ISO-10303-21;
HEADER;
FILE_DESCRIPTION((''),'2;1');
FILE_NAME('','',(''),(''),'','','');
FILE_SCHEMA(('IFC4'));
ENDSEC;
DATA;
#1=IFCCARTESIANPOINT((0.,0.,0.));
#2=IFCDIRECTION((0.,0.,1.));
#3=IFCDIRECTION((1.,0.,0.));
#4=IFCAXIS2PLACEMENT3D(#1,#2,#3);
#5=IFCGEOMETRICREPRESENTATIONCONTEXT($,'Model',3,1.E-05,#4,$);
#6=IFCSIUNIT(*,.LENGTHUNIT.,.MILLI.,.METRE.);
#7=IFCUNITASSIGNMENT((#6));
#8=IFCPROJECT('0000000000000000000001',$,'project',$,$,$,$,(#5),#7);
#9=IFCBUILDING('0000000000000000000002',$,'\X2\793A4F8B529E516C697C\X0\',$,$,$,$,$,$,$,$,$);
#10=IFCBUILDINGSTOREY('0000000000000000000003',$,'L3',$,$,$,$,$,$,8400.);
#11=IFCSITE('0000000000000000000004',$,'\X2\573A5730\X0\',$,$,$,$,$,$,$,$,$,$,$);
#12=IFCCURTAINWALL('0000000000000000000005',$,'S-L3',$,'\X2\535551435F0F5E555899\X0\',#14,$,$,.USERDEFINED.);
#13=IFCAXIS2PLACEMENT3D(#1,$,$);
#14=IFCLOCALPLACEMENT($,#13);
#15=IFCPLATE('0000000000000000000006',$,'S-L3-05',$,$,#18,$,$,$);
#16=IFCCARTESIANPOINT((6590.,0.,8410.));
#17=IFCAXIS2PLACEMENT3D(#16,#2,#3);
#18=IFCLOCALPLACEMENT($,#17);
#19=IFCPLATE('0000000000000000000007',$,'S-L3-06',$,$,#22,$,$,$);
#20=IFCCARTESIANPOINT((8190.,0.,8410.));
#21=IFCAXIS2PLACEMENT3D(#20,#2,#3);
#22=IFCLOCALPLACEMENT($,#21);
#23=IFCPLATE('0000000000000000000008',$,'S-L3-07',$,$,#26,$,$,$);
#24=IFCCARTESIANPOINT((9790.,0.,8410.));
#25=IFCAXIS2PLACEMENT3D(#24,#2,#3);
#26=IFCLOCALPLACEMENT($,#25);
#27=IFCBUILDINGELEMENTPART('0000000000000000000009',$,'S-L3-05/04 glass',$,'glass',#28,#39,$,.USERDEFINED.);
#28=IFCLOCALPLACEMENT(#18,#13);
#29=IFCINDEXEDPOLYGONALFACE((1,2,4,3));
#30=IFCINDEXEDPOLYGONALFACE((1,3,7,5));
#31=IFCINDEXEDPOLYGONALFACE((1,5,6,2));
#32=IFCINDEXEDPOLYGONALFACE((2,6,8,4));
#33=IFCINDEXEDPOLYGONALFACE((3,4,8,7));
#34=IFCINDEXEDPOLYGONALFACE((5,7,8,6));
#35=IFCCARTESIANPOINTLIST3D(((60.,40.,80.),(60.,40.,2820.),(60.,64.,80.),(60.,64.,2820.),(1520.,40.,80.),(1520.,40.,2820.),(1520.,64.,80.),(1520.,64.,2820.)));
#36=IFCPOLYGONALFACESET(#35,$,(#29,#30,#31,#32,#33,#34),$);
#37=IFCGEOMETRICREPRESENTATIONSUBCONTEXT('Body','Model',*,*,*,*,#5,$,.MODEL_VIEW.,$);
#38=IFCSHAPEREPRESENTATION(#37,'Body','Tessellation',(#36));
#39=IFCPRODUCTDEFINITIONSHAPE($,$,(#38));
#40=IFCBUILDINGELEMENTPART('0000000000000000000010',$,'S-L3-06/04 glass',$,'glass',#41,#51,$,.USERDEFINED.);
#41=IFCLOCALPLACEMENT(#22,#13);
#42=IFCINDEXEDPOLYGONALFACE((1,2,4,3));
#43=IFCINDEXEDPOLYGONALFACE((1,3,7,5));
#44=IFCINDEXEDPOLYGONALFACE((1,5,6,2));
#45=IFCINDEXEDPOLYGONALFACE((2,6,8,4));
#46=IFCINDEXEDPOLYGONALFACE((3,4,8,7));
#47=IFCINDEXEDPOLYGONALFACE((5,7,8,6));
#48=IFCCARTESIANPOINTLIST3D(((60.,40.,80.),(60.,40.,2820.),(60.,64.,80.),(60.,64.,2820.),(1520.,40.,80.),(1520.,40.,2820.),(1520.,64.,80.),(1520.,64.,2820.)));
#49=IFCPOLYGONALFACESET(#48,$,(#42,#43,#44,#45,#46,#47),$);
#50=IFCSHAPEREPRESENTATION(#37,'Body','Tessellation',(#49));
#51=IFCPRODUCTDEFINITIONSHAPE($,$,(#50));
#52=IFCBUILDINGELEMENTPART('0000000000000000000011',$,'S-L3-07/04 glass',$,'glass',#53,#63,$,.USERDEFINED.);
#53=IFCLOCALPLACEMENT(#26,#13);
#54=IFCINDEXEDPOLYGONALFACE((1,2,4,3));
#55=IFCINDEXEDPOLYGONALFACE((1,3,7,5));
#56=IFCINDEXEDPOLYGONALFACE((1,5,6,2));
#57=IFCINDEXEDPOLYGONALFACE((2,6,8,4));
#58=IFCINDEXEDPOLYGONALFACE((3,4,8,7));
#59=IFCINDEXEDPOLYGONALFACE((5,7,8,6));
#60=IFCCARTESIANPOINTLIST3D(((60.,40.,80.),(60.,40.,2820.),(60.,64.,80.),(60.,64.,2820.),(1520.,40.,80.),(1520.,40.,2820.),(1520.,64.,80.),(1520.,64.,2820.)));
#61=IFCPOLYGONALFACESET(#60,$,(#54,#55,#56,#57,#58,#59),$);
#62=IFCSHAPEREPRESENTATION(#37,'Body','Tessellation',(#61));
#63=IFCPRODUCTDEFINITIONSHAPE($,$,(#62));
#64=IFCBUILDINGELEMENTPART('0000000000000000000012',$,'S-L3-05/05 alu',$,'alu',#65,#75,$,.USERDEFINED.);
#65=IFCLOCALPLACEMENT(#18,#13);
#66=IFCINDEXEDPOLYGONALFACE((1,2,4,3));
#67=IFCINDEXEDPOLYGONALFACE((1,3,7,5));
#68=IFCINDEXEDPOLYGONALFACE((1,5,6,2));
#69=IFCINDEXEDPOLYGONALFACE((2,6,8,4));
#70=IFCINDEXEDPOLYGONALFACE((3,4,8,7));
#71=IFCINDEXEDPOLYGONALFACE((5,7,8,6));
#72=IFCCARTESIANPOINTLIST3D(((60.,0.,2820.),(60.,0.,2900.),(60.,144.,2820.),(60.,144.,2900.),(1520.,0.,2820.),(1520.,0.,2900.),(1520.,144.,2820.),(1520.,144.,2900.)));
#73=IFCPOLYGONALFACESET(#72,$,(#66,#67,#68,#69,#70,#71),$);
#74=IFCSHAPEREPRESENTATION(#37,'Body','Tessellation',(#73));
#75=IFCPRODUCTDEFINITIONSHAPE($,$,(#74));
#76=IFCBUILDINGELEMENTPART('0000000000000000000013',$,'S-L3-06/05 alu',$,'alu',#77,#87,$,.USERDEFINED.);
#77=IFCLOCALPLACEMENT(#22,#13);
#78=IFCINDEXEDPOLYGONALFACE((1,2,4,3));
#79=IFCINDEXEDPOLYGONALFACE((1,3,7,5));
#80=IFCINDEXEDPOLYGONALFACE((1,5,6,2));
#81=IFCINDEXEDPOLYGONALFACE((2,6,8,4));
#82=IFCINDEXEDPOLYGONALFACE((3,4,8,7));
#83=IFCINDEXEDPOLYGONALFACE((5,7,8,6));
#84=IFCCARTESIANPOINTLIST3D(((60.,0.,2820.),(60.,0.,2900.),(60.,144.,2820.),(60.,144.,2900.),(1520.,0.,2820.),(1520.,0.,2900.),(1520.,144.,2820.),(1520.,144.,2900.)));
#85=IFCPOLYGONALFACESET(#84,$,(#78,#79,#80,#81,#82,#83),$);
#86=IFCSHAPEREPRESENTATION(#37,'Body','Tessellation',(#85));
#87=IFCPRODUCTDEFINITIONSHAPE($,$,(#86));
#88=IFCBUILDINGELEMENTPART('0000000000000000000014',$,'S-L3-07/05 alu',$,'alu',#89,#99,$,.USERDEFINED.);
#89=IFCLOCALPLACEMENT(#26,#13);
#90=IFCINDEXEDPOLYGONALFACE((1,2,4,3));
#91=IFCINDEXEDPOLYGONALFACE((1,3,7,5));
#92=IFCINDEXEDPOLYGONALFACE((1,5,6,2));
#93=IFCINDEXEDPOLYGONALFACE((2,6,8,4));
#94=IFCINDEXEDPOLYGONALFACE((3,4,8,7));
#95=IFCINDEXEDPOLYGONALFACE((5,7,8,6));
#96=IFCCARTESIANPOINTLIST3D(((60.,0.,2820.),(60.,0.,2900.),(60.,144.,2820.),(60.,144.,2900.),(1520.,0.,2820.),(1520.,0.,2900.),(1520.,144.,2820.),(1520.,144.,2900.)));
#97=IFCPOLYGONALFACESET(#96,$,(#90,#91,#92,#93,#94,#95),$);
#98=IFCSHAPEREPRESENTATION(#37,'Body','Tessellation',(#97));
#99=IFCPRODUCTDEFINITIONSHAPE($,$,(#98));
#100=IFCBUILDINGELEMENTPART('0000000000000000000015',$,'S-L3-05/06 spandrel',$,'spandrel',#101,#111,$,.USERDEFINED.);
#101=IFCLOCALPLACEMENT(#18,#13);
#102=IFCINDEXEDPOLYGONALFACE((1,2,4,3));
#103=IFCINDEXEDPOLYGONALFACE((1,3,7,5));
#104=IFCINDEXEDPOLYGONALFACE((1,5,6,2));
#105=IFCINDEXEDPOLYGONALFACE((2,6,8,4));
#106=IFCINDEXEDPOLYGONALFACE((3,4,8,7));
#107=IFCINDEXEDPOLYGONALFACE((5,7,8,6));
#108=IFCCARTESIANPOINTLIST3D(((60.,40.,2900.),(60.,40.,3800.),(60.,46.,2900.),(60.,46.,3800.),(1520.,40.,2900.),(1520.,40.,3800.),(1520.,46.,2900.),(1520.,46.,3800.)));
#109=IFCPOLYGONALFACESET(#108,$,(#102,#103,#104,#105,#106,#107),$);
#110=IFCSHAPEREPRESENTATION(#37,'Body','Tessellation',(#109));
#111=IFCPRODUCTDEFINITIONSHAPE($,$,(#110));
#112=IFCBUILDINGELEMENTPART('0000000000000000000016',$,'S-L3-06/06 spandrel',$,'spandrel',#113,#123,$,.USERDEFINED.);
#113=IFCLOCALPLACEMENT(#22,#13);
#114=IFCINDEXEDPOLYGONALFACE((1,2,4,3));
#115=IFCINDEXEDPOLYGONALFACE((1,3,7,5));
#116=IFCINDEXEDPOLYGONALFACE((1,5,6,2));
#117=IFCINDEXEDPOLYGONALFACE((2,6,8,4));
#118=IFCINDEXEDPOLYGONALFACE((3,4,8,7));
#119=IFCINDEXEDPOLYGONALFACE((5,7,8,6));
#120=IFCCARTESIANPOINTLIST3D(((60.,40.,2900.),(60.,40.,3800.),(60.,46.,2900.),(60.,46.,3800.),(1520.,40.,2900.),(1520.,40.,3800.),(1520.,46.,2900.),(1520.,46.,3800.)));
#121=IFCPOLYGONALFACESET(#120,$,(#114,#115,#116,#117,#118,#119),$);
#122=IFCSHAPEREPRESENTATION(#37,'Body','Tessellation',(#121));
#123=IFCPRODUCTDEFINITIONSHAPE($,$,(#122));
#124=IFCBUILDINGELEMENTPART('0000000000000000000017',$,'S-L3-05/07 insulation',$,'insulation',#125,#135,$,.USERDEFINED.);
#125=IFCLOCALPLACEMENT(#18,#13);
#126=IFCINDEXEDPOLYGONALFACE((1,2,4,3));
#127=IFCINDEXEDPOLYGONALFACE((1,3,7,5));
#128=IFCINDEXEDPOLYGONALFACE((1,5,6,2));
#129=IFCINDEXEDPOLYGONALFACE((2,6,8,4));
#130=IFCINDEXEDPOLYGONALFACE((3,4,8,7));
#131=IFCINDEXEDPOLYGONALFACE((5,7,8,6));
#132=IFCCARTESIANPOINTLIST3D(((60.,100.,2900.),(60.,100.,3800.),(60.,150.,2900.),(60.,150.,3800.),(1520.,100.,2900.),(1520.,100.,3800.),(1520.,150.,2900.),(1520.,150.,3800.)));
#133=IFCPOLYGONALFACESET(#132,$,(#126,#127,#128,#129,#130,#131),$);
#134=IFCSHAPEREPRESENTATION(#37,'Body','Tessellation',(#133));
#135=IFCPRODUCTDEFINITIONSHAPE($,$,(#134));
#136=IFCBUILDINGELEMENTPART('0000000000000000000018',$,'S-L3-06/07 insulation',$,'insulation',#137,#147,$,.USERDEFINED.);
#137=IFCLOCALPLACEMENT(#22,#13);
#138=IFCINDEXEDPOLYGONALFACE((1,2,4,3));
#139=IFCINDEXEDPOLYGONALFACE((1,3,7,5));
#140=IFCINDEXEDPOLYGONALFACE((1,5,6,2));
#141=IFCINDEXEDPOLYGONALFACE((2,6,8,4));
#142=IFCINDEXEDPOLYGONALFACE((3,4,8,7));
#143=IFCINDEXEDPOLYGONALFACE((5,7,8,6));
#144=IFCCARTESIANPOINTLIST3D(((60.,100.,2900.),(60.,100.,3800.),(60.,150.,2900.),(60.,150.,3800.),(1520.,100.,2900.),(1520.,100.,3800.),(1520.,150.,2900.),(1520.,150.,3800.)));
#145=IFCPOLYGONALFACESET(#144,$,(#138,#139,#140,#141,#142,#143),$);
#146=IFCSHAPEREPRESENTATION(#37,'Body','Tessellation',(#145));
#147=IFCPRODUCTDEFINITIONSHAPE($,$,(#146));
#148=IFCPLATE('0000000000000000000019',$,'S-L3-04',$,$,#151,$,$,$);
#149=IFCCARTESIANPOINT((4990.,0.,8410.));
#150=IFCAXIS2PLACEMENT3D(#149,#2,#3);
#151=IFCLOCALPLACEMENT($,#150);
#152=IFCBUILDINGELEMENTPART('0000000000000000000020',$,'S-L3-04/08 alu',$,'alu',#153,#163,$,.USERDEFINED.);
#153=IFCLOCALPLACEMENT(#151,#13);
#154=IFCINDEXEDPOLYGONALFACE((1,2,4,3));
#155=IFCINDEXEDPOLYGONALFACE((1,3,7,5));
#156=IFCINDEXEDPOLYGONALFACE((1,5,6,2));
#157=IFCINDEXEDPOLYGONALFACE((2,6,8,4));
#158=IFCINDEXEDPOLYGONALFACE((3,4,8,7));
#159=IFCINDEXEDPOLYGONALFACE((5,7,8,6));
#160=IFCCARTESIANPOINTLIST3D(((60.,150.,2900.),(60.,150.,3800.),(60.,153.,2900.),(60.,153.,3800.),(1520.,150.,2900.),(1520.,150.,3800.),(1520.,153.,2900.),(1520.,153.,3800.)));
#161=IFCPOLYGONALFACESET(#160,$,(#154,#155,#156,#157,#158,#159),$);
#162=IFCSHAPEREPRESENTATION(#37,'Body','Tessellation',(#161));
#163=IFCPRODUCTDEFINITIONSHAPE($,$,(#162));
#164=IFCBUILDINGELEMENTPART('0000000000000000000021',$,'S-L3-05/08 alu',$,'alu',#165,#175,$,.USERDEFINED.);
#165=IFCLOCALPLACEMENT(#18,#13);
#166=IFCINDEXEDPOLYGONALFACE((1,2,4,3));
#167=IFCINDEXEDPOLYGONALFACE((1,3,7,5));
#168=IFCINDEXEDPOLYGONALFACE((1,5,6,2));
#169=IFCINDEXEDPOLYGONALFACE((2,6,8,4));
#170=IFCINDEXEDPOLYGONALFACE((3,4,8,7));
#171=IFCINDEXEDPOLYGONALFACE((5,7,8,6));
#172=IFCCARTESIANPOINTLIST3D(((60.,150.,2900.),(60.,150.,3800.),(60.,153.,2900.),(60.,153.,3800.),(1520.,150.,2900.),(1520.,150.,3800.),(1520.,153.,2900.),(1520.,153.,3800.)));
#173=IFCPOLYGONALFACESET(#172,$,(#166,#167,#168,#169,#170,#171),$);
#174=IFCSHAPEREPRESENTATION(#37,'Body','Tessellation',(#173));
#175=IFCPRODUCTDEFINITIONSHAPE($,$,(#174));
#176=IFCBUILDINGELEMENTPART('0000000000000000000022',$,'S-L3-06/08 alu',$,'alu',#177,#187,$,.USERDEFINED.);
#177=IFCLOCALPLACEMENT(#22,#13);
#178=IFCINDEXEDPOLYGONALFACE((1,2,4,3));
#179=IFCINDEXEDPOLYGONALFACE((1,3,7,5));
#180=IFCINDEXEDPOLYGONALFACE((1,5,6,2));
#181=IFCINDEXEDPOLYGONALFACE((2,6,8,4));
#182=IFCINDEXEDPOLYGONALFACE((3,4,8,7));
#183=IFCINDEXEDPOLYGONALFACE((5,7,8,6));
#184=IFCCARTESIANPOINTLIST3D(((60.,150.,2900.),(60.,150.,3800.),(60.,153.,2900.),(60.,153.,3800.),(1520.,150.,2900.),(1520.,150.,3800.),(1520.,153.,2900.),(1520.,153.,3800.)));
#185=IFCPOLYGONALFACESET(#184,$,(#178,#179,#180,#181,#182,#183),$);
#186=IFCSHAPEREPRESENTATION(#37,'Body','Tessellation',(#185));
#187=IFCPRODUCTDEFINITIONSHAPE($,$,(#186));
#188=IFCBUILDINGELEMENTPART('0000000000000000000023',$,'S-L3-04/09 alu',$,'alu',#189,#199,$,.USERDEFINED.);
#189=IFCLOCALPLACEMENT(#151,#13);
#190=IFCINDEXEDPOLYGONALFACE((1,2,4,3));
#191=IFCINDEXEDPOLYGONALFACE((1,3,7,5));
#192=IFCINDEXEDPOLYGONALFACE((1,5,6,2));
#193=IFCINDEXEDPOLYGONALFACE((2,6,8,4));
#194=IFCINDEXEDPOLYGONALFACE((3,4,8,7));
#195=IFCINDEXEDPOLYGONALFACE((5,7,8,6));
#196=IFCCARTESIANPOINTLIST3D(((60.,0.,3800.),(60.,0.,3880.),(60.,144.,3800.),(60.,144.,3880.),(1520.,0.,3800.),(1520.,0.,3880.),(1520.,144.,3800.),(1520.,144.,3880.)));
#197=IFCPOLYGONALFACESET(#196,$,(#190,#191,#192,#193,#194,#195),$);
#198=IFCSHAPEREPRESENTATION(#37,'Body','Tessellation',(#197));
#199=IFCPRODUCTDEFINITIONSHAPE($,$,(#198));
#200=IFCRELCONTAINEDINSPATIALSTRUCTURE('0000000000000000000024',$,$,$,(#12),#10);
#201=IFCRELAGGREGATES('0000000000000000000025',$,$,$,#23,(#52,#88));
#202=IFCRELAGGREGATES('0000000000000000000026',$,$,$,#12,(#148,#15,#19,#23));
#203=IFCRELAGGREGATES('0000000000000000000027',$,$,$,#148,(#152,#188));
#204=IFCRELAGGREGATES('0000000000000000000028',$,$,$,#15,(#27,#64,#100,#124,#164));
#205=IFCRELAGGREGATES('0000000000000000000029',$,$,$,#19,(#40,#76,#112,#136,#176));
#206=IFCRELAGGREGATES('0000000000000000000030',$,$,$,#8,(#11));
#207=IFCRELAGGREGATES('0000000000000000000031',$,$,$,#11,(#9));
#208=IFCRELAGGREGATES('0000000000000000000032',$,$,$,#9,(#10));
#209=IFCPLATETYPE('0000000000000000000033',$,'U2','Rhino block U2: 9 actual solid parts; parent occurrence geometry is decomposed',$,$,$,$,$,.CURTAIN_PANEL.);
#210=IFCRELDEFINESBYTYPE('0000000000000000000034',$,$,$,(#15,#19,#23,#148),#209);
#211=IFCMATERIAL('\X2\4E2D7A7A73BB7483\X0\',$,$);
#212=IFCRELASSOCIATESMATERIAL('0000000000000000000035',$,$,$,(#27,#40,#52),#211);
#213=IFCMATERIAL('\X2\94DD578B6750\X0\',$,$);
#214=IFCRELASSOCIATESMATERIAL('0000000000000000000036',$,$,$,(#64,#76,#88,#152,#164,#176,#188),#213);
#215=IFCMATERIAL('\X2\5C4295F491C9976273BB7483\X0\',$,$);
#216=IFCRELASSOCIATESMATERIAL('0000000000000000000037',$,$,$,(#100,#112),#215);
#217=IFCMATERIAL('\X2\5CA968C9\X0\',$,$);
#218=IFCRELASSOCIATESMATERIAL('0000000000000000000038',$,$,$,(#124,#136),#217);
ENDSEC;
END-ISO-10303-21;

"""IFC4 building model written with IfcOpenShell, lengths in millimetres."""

from ifc_helpers import new_model, si_unit, frame, frame_2d, origin, origin_with_axes, place, context, subcontext, project, spatial, rectangle, extrude, source, transform, mapped, material, type_object, element, aggregate, save


model = new_model("IFC4")

# Units and contexts
model_context = context("Model", 3, precision=1e-05, world=origin_with_axes())
body_context = subcontext(model_context, "Body", "Model", "MODEL_VIEW")
ifc_project = project(units=[si_unit("LENGTHUNIT", "METRE", prefix="MILLI")], contexts=[model_context])

# Site, building, storey
site = spatial("IfcSite", under=ifc_project, Name="场地")
building = spatial("IfcBuilding", under=site, Name="示例办公楼")
storey = spatial("IfcBuildingStorey", under=building, Name="L3", Elevation=8400.0)

# Curtain wall, plates, building element parts
curtain_wall = element("IfcCurtainWall", 1, inside=storey, Name="S-L3", ObjectType="单元式幕墙", PredefinedType="USERDEFINED")
plate_type = type_object("IfcPlateType", Name="U2", Description="Rhino block U2: 9 actual solid parts; parent occurrence geometry is decomposed", PredefinedType="CURTAIN_PANEL")
plate_1_placement = place(None, frame((6590.0, 0.0, 8410.0), z_axis=(0.0, 0.0, 1.0), x_axis=(1.0, 0.0, 0.0)))
plate_1 = element("IfcPlate", 2, at=plate_1_placement, type_object=plate_type, Name="S-L3-05")
ifc_material_1 = material(Name="铝型材")
plate_2_placement = place(None, frame((8190.0, 0.0, 8410.0), z_axis=(0.0, 0.0, 1.0), x_axis=(1.0, 0.0, 0.0)))
plate_2 = element("IfcPlate", 3, at=plate_2_placement, type_object=plate_type, Name="S-L3-06")
plate_3_placement = place(None, frame((9790.0, 0.0, 8410.0), z_axis=(0.0, 0.0, 1.0), x_axis=(1.0, 0.0, 0.0)))
plate_3 = element("IfcPlate", 4, at=plate_3_placement, type_object=plate_type, Name="S-L3-07")
ifc_material_2 = material(Name="中空玻璃")
shared_shape_1 = source(origin(), body_context, "Body", "SweptSolid", [
    extrude(rectangle(XDim=1460.0, YDim=24.0, at=frame_2d((790.0, 52.0))), frame((0.0, 0.0, 80.0)), (0.0, 0.0, 1.0), 2740.0),
])
building_element_part_1_placement = place(plate_1_placement, origin())
building_element_part_1 = element("IfcBuildingElementPart", 5, at=building_element_part_1_placement, material=ifc_material_2, Name="S-L3-05/04 glass", ObjectType="glass", PredefinedType="USERDEFINED", context=body_context, shape_type="MappedRepresentation", body=[
    mapped(shared_shape_1, transform((0.0, 0.0, 0.0))),
])
building_element_part_2_placement = place(plate_2_placement, origin())
building_element_part_2 = element("IfcBuildingElementPart", 6, at=building_element_part_2_placement, material=ifc_material_2, Name="S-L3-06/04 glass", ObjectType="glass", PredefinedType="USERDEFINED", context=body_context, shape_type="MappedRepresentation", body=[
    mapped(shared_shape_1, transform((0.0, 0.0, 0.0))),
])
building_element_part_3_placement = place(plate_3_placement, origin())
building_element_part_3 = element("IfcBuildingElementPart", 7, at=building_element_part_3_placement, material=ifc_material_2, Name="S-L3-07/04 glass", ObjectType="glass", PredefinedType="USERDEFINED", context=body_context, shape_type="MappedRepresentation", body=[
    mapped(shared_shape_1, transform((0.0, 0.0, 0.0))),
])
shared_shape_2 = source(origin(), body_context, "Body", "SweptSolid", [
    extrude(rectangle(XDim=1460.0, YDim=144.0, at=frame_2d((790.0, 72.0))), frame((0.0, 0.0, 2820.0)), (0.0, 0.0, 1.0), 80.0),
])
building_element_part_4_placement = place(plate_1_placement, origin())
building_element_part_4 = element("IfcBuildingElementPart", 8, at=building_element_part_4_placement, material=ifc_material_1, Name="S-L3-05/05 alu", ObjectType="alu", PredefinedType="USERDEFINED", context=body_context, shape_type="MappedRepresentation", body=[
    mapped(shared_shape_2, transform((0.0, 0.0, 0.0))),
])
building_element_part_5_placement = place(plate_2_placement, origin())
building_element_part_5 = element("IfcBuildingElementPart", 9, at=building_element_part_5_placement, material=ifc_material_1, Name="S-L3-06/05 alu", ObjectType="alu", PredefinedType="USERDEFINED", context=body_context, shape_type="MappedRepresentation", body=[
    mapped(shared_shape_2, transform((0.0, 0.0, 0.0))),
])
building_element_part_6_placement = place(plate_3_placement, origin())
building_element_part_6 = element("IfcBuildingElementPart", 10, at=building_element_part_6_placement, material=ifc_material_1, Name="S-L3-07/05 alu", ObjectType="alu", PredefinedType="USERDEFINED", context=body_context, shape_type="MappedRepresentation", body=[
    mapped(shared_shape_2, transform((0.0, 0.0, 0.0))),
])
aggregate(plate_3, [building_element_part_3, building_element_part_6])
ifc_material_3 = material(Name="层间釉面玻璃")
shared_shape_3 = source(origin(), body_context, "Body", "SweptSolid", [
    extrude(rectangle(XDim=1460.0, YDim=6.0, at=frame_2d((790.0, 43.0))), frame((0.0, 0.0, 2900.0)), (0.0, 0.0, 1.0), 900.0),
])
building_element_part_7_placement = place(plate_1_placement, origin())
building_element_part_7 = element("IfcBuildingElementPart", 11, at=building_element_part_7_placement, material=ifc_material_3, Name="S-L3-05/06 spandrel", ObjectType="spandrel", PredefinedType="USERDEFINED", context=body_context, shape_type="MappedRepresentation", body=[
    mapped(shared_shape_3, transform((0.0, 0.0, 0.0))),
])
building_element_part_8_placement = place(plate_2_placement, origin())
building_element_part_8 = element("IfcBuildingElementPart", 12, at=building_element_part_8_placement, material=ifc_material_3, Name="S-L3-06/06 spandrel", ObjectType="spandrel", PredefinedType="USERDEFINED", context=body_context, shape_type="MappedRepresentation", body=[
    mapped(shared_shape_3, transform((0.0, 0.0, 0.0))),
])
ifc_material_4 = material(Name="岩棉")
shared_shape_4 = source(origin(), body_context, "Body", "SweptSolid", [
    extrude(rectangle(XDim=1460.0, YDim=50.0, at=frame_2d((790.0, 125.0))), frame((0.0, 0.0, 2900.0)), (0.0, 0.0, 1.0), 900.0),
])
building_element_part_9_placement = place(plate_1_placement, origin())
building_element_part_9 = element("IfcBuildingElementPart", 13, at=building_element_part_9_placement, material=ifc_material_4, Name="S-L3-05/07 insulation", ObjectType="insulation", PredefinedType="USERDEFINED", context=body_context, shape_type="MappedRepresentation", body=[
    mapped(shared_shape_4, transform((0.0, 0.0, 0.0))),
])
building_element_part_10_placement = place(plate_2_placement, origin())
building_element_part_10 = element("IfcBuildingElementPart", 14, at=building_element_part_10_placement, material=ifc_material_4, Name="S-L3-06/07 insulation", ObjectType="insulation", PredefinedType="USERDEFINED", context=body_context, shape_type="MappedRepresentation", body=[
    mapped(shared_shape_4, transform((0.0, 0.0, 0.0))),
])
plate_4_placement = place(None, frame((4990.0, 0.0, 8410.0), z_axis=(0.0, 0.0, 1.0), x_axis=(1.0, 0.0, 0.0)))
plate_4 = element("IfcPlate", 15, at=plate_4_placement, type_object=plate_type, Name="S-L3-04")
aggregate(curtain_wall, [plate_4, plate_1, plate_2, plate_3])
shared_shape_5 = source(origin(), body_context, "Body", "SweptSolid", [
    extrude(rectangle(XDim=1460.0, YDim=3.0, at=frame_2d((790.0, 151.5))), frame((0.0, 0.0, 2900.0)), (0.0, 0.0, 1.0), 900.0),
])
building_element_part_11_placement = place(plate_4_placement, origin())
building_element_part_11 = element("IfcBuildingElementPart", 16, at=building_element_part_11_placement, material=ifc_material_1, Name="S-L3-04/08 alu", ObjectType="alu", PredefinedType="USERDEFINED", context=body_context, shape_type="MappedRepresentation", body=[
    mapped(shared_shape_5, transform((0.0, 0.0, 0.0))),
])
building_element_part_12_placement = place(plate_1_placement, origin())
building_element_part_12 = element("IfcBuildingElementPart", 17, at=building_element_part_12_placement, material=ifc_material_1, Name="S-L3-05/08 alu", ObjectType="alu", PredefinedType="USERDEFINED", context=body_context, shape_type="MappedRepresentation", body=[
    mapped(shared_shape_5, transform((0.0, 0.0, 0.0))),
])
building_element_part_13_placement = place(plate_2_placement, origin())
building_element_part_13 = element("IfcBuildingElementPart", 18, at=building_element_part_13_placement, material=ifc_material_1, Name="S-L3-06/08 alu", ObjectType="alu", PredefinedType="USERDEFINED", context=body_context, shape_type="MappedRepresentation", body=[
    mapped(shared_shape_5, transform((0.0, 0.0, 0.0))),
])
shared_shape_6 = source(origin(), body_context, "Body", "SweptSolid", [
    extrude(rectangle(XDim=1460.0, YDim=144.0, at=frame_2d((790.0, 72.0))), frame((0.0, 0.0, 3800.0)), (0.0, 0.0, 1.0), 80.0),
])
building_element_part_14_placement = place(plate_4_placement, origin())
building_element_part_14 = element("IfcBuildingElementPart", 19, at=building_element_part_14_placement, material=ifc_material_1, Name="S-L3-04/09 alu", ObjectType="alu", PredefinedType="USERDEFINED", context=body_context, shape_type="MappedRepresentation", body=[
    mapped(shared_shape_6, transform((0.0, 0.0, 0.0))),
])
aggregate(plate_4, [building_element_part_11, building_element_part_14])
aggregate(plate_1, [building_element_part_1, building_element_part_4, building_element_part_7, building_element_part_9, building_element_part_12])
aggregate(plate_2, [building_element_part_2, building_element_part_5, building_element_part_8, building_element_part_10, building_element_part_13])

save(model, "model.ifc")
